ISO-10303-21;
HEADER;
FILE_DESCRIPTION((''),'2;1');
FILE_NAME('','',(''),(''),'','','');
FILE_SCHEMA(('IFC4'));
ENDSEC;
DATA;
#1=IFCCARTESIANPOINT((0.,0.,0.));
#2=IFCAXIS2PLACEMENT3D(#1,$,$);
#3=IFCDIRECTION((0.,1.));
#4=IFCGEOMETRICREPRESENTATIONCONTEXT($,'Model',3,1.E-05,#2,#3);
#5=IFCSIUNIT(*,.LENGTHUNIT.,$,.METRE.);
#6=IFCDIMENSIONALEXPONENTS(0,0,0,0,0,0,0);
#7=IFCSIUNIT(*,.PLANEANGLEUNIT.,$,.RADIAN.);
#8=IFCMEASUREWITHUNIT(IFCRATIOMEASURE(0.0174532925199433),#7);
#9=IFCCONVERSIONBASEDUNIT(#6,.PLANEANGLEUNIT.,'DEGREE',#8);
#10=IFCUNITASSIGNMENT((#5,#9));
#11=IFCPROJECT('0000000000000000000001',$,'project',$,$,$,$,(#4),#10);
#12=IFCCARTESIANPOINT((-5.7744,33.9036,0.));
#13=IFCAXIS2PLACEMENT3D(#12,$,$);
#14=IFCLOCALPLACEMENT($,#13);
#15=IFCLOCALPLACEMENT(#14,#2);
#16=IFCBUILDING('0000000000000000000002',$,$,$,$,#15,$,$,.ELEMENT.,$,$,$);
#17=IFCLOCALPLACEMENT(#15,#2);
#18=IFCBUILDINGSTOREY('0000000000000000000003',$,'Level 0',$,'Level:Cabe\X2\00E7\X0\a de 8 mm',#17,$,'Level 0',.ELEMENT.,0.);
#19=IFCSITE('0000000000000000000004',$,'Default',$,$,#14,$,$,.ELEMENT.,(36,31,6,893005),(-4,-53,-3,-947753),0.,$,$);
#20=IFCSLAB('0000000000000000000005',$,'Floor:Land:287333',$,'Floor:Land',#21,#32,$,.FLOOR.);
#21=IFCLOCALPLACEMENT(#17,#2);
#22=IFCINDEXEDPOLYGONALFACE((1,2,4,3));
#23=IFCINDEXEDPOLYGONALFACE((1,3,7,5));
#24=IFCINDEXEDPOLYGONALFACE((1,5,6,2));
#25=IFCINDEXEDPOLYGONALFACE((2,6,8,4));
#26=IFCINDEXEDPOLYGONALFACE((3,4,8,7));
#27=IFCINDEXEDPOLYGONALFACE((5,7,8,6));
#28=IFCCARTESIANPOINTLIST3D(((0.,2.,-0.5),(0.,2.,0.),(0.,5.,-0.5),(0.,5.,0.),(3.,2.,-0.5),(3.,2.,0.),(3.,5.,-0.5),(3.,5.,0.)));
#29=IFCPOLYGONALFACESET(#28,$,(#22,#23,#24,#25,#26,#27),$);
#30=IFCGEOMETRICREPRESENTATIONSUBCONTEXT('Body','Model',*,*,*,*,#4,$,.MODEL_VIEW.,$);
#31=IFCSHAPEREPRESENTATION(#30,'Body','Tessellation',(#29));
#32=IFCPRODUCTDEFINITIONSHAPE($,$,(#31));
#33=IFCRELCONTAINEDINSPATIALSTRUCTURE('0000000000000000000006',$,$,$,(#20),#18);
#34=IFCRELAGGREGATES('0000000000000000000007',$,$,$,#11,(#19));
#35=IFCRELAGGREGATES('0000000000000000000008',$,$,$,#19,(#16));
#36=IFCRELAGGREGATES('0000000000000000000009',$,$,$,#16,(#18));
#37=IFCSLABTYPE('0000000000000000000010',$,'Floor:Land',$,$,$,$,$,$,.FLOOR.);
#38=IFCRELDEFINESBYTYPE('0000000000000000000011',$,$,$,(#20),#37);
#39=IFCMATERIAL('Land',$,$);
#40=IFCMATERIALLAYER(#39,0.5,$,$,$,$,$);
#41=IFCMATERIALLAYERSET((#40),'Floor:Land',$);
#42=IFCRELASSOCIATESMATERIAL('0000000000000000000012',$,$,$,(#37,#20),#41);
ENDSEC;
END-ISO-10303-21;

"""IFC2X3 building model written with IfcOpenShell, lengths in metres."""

from ifc_helpers import new_model, entity, si_unit, converted_unit, direction, frame, frame_2d, origin, place, context, subcontext, project, spatial, rectangle, extrude, material, layer, layer_set, layer_usage, type_object, element, save


model = new_model("IFC2X3")

# Units and contexts
model_context = context("Model", 3, precision=1e-05, world=origin(), true_north=direction((0.0, 1.0)))
body_context = subcontext(model_context, "Body", "Model", "MODEL_VIEW")
ifc_project = project(units=[si_unit("LENGTHUNIT", "METRE"), converted_unit("PLANEANGLEUNIT", "DEGREE", entity("IfcRatioMeasure", 0.0174532925199433), si_unit("PLANEANGLEUNIT", "RADIAN"), dimensions=[0, 0, 0, 0, 0, 0, 0])], contexts=[model_context])

# Site, building, storey
site_placement = place(None, frame((-5.7744, 33.9036, 0.0)))
site = spatial("IfcSite", under=ifc_project, at=site_placement, Name="Default", CompositionType="ELEMENT", RefLatitude=(36, 31, 6, 893005), RefLongitude=(-4, -53, -3, -947753), RefElevation=0.0)
building_placement = place(site_placement, origin())
building = spatial("IfcBuilding", under=site, at=building_placement, CompositionType="ELEMENT")
storey_placement = place(building_placement, origin())
storey = spatial("IfcBuildingStorey", under=building, at=storey_placement, Name="Level 0", ObjectType="Level:Cabeça de 8 mm", LongName="Level 0", CompositionType="ELEMENT", Elevation=0.0)

# Slab
ifc_material = material(Name="Land")
ifc_layer = layer(ifc_material, 0.5)
ifc_layer_set = layer_set([ifc_layer], Name="Floor:Land")
ifc_layer_usage = layer_usage(ifc_layer_set, "AXIS3", "POSITIVE", 0.0)
slab_type = type_object("IfcSlabType", Name="Floor:Land", PredefinedType="FLOOR", material=ifc_layer_set)
slab_placement = place(storey_placement, origin())
element("IfcSlab", 1, at=slab_placement, inside=storey, type_object=slab_type, material=ifc_layer_usage, Name="Floor:Land:287333", ObjectType="Floor:Land", PredefinedType="FLOOR", context=body_context, shape_type="SweptSolid", body=[
    extrude(rectangle(XDim=3.0, YDim=3.0, at=frame_2d((0.0, 0.0), x_axis=(1.0, 0.0))), frame((1.5, 3.5, 0.0), z_axis=(0.0, 0.0, -1.0), x_axis=(0.0, 1.0, 0.0)), (0.0, 0.0, 1.0), 0.5),
])

save(model, "model.ifc")
